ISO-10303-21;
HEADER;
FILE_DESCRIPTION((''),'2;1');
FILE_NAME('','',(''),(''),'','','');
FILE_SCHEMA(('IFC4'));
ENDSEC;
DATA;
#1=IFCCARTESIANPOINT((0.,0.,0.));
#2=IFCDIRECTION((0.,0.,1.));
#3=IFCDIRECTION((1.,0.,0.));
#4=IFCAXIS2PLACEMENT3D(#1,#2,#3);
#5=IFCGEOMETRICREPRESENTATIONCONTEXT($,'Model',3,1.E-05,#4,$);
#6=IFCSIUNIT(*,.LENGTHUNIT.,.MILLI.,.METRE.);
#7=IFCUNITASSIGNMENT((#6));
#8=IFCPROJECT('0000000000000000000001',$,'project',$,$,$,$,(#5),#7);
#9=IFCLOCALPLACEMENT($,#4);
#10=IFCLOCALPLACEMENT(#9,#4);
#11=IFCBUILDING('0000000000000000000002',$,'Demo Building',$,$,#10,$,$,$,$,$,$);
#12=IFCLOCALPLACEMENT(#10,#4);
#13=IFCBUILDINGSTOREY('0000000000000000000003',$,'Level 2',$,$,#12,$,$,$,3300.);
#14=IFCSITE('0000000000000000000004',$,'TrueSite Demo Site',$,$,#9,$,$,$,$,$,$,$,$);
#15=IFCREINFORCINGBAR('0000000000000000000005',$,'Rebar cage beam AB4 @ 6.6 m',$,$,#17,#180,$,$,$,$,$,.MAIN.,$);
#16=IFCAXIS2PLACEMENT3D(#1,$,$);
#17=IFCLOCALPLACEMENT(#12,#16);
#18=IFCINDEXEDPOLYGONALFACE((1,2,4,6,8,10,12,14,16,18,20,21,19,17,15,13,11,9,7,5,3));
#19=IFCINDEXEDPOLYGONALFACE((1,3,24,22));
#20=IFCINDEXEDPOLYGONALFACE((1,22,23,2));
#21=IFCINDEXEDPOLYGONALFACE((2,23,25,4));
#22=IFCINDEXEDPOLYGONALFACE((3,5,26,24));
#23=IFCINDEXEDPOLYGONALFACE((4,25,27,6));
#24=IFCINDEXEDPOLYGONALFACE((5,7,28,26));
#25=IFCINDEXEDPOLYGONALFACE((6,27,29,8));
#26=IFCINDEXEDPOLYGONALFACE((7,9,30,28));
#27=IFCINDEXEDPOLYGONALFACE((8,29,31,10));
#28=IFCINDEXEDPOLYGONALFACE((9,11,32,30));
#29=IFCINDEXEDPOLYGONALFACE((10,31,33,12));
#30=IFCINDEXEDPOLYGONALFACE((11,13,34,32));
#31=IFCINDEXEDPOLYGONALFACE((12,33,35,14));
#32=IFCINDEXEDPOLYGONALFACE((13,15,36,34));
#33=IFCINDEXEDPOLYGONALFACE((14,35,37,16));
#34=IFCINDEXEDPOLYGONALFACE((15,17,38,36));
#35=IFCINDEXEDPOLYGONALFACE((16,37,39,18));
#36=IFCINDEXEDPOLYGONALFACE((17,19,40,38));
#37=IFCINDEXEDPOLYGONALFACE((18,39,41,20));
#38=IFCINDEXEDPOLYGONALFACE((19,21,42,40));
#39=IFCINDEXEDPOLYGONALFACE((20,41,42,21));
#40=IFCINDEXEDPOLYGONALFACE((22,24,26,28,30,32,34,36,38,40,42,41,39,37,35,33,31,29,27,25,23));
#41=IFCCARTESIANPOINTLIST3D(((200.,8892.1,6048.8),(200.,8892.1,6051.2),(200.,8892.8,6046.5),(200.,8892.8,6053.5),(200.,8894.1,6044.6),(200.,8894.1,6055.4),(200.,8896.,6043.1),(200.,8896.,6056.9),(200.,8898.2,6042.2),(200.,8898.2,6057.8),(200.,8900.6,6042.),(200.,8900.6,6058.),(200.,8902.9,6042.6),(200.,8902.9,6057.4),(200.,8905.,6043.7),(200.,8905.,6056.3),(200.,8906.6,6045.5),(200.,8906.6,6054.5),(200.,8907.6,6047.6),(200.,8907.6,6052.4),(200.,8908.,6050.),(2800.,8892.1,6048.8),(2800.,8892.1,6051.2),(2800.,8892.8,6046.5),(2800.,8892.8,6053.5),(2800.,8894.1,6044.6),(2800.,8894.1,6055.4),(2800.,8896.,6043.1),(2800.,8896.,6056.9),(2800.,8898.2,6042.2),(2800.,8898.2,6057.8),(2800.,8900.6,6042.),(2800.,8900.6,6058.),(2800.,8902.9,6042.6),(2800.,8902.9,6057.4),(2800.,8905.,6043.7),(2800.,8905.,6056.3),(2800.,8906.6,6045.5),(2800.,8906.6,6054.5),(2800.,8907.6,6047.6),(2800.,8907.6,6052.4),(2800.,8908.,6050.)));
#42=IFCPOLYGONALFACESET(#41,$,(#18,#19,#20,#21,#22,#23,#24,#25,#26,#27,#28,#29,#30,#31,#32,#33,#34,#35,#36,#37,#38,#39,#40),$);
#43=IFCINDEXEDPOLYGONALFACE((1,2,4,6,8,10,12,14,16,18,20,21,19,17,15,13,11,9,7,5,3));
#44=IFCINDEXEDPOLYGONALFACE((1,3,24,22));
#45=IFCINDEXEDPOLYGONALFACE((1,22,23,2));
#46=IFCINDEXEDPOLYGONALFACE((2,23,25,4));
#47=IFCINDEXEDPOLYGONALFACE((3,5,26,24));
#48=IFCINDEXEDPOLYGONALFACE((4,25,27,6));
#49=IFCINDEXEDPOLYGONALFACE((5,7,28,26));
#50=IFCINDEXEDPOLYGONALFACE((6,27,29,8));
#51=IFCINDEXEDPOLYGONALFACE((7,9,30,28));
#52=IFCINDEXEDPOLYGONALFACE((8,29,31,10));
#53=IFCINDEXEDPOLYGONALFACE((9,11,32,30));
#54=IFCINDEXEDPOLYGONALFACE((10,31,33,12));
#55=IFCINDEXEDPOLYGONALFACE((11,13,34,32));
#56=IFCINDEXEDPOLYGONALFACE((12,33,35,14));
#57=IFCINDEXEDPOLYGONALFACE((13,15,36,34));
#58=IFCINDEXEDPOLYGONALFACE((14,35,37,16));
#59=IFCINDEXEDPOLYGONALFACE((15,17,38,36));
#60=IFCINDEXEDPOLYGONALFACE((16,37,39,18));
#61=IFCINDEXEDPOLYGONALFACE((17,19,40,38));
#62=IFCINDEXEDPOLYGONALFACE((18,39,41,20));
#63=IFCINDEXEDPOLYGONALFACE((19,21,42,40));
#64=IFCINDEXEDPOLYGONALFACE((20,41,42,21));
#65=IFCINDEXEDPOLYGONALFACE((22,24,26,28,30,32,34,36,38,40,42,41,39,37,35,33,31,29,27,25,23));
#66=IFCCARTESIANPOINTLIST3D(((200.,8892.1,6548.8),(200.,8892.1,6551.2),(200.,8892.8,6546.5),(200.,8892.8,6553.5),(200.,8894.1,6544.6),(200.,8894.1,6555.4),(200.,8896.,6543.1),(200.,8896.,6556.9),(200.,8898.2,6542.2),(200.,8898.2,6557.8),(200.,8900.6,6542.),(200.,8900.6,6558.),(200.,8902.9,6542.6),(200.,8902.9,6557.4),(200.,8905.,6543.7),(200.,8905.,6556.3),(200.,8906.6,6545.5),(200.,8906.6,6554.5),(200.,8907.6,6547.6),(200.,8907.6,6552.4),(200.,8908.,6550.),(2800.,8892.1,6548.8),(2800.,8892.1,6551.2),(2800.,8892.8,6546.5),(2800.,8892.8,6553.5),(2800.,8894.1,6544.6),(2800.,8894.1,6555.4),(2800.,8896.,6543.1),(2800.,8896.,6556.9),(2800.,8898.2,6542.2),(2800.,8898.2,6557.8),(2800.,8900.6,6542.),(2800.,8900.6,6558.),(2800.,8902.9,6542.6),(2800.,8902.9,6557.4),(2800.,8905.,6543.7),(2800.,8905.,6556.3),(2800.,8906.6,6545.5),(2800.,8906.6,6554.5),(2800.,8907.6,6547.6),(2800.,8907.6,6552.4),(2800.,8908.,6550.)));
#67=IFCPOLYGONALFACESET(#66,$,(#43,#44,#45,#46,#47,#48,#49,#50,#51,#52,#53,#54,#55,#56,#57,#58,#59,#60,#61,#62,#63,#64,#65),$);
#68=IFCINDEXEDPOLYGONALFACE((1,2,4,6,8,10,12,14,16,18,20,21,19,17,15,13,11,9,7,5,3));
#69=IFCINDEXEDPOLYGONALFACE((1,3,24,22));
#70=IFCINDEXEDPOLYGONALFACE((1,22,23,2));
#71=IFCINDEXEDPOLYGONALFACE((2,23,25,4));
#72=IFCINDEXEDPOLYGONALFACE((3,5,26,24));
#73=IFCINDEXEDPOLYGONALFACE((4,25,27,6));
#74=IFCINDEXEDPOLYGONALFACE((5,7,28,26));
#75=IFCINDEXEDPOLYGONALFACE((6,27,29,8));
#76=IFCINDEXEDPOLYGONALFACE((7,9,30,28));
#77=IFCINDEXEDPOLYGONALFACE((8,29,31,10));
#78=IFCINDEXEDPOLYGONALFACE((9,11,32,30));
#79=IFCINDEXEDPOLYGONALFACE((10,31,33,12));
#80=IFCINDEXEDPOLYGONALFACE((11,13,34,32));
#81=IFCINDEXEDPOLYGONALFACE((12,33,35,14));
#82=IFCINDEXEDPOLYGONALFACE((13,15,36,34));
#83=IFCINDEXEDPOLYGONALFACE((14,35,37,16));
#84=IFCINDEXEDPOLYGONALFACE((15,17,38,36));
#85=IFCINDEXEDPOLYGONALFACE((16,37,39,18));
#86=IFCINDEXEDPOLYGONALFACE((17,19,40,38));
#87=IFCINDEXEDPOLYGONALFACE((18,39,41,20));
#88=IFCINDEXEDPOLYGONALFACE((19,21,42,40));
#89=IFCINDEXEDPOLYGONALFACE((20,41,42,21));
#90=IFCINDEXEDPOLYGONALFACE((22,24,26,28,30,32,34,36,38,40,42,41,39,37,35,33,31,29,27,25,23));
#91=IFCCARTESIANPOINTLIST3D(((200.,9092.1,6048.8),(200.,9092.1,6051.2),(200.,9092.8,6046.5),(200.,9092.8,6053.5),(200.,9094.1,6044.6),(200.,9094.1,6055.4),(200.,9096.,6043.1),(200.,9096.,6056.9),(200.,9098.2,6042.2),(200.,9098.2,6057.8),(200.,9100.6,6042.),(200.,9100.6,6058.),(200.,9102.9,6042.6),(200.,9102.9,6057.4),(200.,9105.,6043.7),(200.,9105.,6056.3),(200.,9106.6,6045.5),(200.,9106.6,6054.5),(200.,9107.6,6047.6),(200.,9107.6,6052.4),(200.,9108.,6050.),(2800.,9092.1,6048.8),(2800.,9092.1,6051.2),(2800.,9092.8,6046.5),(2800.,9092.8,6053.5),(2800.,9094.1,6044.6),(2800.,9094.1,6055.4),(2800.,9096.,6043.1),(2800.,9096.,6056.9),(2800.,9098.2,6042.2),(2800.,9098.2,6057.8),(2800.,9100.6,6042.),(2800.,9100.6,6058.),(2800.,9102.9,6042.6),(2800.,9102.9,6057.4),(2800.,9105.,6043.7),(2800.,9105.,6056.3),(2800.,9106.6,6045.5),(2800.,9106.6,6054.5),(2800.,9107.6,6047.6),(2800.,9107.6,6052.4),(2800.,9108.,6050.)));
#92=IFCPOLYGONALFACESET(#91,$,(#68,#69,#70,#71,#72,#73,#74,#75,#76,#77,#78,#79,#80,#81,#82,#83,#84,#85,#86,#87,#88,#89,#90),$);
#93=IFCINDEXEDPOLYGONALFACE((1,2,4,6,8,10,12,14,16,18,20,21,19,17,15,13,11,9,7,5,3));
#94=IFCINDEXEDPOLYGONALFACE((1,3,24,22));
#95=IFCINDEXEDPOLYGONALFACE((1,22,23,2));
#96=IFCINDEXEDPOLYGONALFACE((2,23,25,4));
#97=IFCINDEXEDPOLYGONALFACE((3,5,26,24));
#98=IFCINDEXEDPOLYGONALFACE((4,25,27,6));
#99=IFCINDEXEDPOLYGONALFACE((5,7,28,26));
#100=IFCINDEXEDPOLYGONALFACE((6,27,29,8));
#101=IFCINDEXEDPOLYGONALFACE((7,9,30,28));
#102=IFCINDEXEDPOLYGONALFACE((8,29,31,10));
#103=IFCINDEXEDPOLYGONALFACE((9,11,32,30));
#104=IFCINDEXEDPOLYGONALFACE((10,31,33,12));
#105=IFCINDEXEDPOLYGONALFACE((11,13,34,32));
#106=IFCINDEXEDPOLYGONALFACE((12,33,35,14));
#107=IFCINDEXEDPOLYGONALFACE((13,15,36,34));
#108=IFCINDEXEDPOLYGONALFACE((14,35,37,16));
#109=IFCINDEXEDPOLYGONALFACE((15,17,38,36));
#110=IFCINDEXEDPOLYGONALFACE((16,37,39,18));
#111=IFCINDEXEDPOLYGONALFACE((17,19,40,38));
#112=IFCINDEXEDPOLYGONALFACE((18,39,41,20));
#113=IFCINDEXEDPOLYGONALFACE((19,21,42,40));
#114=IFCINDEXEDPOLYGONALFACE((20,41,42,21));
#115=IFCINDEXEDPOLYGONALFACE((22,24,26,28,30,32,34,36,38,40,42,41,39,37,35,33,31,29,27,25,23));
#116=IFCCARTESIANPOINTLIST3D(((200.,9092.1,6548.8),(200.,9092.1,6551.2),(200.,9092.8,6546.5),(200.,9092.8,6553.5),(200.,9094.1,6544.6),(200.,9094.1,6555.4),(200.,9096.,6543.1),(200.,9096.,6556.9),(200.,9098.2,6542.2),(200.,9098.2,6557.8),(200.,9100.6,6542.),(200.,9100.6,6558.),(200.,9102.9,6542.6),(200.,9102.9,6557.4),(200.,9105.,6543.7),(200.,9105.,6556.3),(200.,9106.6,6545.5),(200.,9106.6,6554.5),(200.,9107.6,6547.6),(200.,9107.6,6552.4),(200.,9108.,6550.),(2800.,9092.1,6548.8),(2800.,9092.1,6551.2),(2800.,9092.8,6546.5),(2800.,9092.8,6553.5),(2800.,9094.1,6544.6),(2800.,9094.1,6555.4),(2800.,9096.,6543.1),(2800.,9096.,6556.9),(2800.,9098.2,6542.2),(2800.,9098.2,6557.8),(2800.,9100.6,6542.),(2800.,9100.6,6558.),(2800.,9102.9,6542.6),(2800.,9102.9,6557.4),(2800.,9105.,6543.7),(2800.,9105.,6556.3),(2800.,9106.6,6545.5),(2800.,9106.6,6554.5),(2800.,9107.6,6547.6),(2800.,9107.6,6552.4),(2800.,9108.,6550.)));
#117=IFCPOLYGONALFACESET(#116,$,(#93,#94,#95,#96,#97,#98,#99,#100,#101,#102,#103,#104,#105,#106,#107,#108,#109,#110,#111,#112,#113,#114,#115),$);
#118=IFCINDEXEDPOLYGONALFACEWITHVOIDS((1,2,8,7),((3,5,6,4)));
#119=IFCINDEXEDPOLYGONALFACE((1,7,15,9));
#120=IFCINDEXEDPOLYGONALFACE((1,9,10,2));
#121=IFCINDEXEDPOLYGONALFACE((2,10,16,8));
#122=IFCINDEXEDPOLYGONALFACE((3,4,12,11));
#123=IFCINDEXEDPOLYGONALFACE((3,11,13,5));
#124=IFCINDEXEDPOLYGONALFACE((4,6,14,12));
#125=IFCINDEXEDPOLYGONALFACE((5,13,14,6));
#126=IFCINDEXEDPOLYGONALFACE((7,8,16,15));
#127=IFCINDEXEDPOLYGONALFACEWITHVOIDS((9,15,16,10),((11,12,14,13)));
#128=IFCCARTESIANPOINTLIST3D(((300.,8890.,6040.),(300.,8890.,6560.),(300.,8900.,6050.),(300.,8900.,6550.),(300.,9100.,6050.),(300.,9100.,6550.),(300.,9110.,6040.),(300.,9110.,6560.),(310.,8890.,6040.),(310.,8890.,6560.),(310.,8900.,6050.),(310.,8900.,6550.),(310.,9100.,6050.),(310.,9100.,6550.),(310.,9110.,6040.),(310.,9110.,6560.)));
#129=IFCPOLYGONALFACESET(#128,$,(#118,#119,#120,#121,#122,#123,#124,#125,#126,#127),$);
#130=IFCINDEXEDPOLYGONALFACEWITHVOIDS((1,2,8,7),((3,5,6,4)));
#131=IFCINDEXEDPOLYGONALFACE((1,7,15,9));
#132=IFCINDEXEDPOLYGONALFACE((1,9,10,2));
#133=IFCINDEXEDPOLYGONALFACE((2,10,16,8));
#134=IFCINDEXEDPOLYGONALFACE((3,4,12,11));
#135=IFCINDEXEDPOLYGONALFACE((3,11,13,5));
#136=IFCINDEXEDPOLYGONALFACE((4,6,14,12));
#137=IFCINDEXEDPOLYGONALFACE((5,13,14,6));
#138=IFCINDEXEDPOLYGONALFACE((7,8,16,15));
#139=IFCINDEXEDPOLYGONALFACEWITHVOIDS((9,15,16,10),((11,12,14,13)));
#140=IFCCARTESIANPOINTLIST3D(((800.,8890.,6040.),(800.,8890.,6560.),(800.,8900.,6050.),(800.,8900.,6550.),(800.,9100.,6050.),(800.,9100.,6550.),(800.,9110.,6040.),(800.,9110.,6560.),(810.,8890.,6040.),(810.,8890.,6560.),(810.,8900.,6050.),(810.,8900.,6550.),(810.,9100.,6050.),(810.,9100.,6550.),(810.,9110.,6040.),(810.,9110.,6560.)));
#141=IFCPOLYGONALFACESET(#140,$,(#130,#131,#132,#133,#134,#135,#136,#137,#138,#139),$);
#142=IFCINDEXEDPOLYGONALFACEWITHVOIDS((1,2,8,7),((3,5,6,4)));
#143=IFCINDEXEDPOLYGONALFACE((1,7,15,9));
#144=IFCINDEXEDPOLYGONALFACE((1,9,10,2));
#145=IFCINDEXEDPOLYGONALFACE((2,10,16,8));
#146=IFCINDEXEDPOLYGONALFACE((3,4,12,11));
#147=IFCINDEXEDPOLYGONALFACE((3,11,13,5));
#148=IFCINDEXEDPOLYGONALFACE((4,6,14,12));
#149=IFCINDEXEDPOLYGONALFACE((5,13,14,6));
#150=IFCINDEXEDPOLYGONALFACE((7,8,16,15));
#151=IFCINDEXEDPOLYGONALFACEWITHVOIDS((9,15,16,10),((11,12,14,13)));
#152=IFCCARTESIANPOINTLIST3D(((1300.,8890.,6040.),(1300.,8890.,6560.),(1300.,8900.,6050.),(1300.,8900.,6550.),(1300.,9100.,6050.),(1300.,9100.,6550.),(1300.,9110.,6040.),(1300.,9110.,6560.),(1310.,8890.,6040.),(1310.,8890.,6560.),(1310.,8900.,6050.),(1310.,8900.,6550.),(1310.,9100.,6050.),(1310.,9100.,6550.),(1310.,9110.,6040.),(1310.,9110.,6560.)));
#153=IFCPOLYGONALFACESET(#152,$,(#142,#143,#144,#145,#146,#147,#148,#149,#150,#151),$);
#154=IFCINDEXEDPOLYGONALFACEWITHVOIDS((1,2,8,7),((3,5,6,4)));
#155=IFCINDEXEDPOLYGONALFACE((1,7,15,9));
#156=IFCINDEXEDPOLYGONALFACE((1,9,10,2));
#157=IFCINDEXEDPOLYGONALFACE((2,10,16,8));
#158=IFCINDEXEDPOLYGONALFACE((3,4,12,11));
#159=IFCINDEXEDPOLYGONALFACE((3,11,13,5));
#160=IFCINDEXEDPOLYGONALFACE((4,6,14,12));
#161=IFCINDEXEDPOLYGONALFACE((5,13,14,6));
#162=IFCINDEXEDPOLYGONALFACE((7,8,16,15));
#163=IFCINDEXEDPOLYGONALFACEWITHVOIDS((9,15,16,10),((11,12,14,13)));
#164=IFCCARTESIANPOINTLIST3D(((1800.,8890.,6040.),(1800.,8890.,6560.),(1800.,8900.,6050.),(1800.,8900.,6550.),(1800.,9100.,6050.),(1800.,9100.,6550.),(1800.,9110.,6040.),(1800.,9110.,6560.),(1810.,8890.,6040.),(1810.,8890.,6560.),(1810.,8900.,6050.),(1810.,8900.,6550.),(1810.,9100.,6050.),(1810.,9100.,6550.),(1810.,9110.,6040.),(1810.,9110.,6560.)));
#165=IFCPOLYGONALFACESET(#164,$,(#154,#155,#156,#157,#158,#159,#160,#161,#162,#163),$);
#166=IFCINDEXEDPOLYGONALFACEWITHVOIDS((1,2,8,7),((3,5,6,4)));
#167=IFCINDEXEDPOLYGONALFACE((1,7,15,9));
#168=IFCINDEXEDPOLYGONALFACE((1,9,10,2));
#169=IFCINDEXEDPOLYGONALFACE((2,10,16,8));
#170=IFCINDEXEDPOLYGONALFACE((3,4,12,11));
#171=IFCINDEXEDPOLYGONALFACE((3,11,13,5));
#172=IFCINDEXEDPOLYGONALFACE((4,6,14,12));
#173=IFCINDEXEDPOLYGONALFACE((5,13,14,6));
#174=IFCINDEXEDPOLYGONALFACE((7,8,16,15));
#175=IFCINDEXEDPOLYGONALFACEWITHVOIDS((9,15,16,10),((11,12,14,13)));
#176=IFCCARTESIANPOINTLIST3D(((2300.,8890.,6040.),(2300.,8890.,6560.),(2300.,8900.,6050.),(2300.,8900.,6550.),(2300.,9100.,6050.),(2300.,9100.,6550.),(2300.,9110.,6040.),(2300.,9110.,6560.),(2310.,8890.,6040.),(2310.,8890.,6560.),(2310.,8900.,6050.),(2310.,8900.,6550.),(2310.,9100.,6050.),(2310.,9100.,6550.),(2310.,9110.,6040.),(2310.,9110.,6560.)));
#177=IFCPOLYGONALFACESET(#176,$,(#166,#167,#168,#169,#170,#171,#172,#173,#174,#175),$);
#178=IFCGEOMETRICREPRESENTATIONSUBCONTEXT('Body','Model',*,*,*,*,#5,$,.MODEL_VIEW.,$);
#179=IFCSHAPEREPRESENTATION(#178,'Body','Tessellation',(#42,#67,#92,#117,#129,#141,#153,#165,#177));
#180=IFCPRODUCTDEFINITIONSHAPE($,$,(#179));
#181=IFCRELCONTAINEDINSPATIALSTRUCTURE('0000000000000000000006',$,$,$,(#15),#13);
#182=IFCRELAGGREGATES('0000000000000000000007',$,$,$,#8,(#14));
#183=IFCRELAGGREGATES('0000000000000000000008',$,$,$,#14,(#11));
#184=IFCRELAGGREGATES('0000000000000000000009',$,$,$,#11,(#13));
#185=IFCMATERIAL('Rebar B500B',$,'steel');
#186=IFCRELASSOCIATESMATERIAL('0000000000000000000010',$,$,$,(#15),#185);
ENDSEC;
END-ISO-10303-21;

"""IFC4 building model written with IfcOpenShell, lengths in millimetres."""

from ifc_helpers import new_model, si_unit, frame, origin_with_axes, place, context, subcontext, project, spatial, hollow_rectangle, circle, extrude, material, element, save


model = new_model("IFC4")

# Units and contexts
model_context = context("Model", 3, precision=1e-05, world=origin_with_axes())
body_context = subcontext(model_context, "Body", "Model", "MODEL_VIEW")
ifc_project = project(units=[si_unit("LENGTHUNIT", "METRE", prefix="MILLI")], contexts=[model_context])

# Site, building, storey
site_placement = place(None, origin_with_axes())
site = spatial("IfcSite", under=ifc_project, at=site_placement, Name="TrueSite Demo Site")
building_placement = place(site_placement, origin_with_axes())
building = spatial("IfcBuilding", under=site, at=building_placement, Name="Demo Building")
storey_placement = place(building_placement, origin_with_axes())
storey = spatial("IfcBuildingStorey", under=building, at=storey_placement, Name="Level 2", Elevation=3300.0)

# Reinforcing bar
ifc_material_1 = material(Name="Rebar B500B", Category="steel")
for number, where, z_axis, x_axis, name in (
    (1, (200.0, 9000.0, 6300.0), (1.0, 0.0, 0.0), (0.0, 1.0, 0.0), "Rebar cage beam AB4 @ 6.6 m"),
):
    element("IfcReinforcingBar", number, at=place(storey_placement, frame(where, z_axis=z_axis, x_axis=x_axis)), inside=storey, material=ifc_material_1, Name=name, PredefinedType="MAIN", context=body_context, shape_type="SweptSolid", body=[
        extrude(circle(Radius=8.0), frame((-100.0, -250.0, 0.0)), (0.0, 0.0, 1.0), 2600.0),
        extrude(circle(Radius=8.0), frame((-100.0, 250.0, 0.0)), (0.0, 0.0, 1.0), 2600.0),
        extrude(circle(Radius=8.0), frame((100.0, -250.0, 0.0)), (0.0, 0.0, 1.0), 2600.0),
        extrude(circle(Radius=8.0), frame((100.0, 250.0, 0.0)), (0.0, 0.0, 1.0), 2600.0),
        extrude(hollow_rectangle(XDim=220.0, YDim=520.0, WallThickness=10.0), frame((0.0, 0.0, 100.0)), (0.0, 0.0, 1.0), 10.0),
        extrude(hollow_rectangle(XDim=220.0, YDim=520.0, WallThickness=10.0), frame((0.0, 0.0, 600.0)), (0.0, 0.0, 1.0), 10.0),
        extrude(hollow_rectangle(XDim=220.0, YDim=520.0, WallThickness=10.0), frame((0.0, 0.0, 1100.0)), (0.0, 0.0, 1.0), 10.0),
        extrude(hollow_rectangle(XDim=220.0, YDim=520.0, WallThickness=10.0), frame((0.0, 0.0, 1600.0)), (0.0, 0.0, 1.0), 10.0),
        extrude(hollow_rectangle(XDim=220.0, YDim=520.0, WallThickness=10.0), frame((0.0, 0.0, 2100.0)), (0.0, 0.0, 1.0), 10.0),
    ])

save(model, "model.ifc")
